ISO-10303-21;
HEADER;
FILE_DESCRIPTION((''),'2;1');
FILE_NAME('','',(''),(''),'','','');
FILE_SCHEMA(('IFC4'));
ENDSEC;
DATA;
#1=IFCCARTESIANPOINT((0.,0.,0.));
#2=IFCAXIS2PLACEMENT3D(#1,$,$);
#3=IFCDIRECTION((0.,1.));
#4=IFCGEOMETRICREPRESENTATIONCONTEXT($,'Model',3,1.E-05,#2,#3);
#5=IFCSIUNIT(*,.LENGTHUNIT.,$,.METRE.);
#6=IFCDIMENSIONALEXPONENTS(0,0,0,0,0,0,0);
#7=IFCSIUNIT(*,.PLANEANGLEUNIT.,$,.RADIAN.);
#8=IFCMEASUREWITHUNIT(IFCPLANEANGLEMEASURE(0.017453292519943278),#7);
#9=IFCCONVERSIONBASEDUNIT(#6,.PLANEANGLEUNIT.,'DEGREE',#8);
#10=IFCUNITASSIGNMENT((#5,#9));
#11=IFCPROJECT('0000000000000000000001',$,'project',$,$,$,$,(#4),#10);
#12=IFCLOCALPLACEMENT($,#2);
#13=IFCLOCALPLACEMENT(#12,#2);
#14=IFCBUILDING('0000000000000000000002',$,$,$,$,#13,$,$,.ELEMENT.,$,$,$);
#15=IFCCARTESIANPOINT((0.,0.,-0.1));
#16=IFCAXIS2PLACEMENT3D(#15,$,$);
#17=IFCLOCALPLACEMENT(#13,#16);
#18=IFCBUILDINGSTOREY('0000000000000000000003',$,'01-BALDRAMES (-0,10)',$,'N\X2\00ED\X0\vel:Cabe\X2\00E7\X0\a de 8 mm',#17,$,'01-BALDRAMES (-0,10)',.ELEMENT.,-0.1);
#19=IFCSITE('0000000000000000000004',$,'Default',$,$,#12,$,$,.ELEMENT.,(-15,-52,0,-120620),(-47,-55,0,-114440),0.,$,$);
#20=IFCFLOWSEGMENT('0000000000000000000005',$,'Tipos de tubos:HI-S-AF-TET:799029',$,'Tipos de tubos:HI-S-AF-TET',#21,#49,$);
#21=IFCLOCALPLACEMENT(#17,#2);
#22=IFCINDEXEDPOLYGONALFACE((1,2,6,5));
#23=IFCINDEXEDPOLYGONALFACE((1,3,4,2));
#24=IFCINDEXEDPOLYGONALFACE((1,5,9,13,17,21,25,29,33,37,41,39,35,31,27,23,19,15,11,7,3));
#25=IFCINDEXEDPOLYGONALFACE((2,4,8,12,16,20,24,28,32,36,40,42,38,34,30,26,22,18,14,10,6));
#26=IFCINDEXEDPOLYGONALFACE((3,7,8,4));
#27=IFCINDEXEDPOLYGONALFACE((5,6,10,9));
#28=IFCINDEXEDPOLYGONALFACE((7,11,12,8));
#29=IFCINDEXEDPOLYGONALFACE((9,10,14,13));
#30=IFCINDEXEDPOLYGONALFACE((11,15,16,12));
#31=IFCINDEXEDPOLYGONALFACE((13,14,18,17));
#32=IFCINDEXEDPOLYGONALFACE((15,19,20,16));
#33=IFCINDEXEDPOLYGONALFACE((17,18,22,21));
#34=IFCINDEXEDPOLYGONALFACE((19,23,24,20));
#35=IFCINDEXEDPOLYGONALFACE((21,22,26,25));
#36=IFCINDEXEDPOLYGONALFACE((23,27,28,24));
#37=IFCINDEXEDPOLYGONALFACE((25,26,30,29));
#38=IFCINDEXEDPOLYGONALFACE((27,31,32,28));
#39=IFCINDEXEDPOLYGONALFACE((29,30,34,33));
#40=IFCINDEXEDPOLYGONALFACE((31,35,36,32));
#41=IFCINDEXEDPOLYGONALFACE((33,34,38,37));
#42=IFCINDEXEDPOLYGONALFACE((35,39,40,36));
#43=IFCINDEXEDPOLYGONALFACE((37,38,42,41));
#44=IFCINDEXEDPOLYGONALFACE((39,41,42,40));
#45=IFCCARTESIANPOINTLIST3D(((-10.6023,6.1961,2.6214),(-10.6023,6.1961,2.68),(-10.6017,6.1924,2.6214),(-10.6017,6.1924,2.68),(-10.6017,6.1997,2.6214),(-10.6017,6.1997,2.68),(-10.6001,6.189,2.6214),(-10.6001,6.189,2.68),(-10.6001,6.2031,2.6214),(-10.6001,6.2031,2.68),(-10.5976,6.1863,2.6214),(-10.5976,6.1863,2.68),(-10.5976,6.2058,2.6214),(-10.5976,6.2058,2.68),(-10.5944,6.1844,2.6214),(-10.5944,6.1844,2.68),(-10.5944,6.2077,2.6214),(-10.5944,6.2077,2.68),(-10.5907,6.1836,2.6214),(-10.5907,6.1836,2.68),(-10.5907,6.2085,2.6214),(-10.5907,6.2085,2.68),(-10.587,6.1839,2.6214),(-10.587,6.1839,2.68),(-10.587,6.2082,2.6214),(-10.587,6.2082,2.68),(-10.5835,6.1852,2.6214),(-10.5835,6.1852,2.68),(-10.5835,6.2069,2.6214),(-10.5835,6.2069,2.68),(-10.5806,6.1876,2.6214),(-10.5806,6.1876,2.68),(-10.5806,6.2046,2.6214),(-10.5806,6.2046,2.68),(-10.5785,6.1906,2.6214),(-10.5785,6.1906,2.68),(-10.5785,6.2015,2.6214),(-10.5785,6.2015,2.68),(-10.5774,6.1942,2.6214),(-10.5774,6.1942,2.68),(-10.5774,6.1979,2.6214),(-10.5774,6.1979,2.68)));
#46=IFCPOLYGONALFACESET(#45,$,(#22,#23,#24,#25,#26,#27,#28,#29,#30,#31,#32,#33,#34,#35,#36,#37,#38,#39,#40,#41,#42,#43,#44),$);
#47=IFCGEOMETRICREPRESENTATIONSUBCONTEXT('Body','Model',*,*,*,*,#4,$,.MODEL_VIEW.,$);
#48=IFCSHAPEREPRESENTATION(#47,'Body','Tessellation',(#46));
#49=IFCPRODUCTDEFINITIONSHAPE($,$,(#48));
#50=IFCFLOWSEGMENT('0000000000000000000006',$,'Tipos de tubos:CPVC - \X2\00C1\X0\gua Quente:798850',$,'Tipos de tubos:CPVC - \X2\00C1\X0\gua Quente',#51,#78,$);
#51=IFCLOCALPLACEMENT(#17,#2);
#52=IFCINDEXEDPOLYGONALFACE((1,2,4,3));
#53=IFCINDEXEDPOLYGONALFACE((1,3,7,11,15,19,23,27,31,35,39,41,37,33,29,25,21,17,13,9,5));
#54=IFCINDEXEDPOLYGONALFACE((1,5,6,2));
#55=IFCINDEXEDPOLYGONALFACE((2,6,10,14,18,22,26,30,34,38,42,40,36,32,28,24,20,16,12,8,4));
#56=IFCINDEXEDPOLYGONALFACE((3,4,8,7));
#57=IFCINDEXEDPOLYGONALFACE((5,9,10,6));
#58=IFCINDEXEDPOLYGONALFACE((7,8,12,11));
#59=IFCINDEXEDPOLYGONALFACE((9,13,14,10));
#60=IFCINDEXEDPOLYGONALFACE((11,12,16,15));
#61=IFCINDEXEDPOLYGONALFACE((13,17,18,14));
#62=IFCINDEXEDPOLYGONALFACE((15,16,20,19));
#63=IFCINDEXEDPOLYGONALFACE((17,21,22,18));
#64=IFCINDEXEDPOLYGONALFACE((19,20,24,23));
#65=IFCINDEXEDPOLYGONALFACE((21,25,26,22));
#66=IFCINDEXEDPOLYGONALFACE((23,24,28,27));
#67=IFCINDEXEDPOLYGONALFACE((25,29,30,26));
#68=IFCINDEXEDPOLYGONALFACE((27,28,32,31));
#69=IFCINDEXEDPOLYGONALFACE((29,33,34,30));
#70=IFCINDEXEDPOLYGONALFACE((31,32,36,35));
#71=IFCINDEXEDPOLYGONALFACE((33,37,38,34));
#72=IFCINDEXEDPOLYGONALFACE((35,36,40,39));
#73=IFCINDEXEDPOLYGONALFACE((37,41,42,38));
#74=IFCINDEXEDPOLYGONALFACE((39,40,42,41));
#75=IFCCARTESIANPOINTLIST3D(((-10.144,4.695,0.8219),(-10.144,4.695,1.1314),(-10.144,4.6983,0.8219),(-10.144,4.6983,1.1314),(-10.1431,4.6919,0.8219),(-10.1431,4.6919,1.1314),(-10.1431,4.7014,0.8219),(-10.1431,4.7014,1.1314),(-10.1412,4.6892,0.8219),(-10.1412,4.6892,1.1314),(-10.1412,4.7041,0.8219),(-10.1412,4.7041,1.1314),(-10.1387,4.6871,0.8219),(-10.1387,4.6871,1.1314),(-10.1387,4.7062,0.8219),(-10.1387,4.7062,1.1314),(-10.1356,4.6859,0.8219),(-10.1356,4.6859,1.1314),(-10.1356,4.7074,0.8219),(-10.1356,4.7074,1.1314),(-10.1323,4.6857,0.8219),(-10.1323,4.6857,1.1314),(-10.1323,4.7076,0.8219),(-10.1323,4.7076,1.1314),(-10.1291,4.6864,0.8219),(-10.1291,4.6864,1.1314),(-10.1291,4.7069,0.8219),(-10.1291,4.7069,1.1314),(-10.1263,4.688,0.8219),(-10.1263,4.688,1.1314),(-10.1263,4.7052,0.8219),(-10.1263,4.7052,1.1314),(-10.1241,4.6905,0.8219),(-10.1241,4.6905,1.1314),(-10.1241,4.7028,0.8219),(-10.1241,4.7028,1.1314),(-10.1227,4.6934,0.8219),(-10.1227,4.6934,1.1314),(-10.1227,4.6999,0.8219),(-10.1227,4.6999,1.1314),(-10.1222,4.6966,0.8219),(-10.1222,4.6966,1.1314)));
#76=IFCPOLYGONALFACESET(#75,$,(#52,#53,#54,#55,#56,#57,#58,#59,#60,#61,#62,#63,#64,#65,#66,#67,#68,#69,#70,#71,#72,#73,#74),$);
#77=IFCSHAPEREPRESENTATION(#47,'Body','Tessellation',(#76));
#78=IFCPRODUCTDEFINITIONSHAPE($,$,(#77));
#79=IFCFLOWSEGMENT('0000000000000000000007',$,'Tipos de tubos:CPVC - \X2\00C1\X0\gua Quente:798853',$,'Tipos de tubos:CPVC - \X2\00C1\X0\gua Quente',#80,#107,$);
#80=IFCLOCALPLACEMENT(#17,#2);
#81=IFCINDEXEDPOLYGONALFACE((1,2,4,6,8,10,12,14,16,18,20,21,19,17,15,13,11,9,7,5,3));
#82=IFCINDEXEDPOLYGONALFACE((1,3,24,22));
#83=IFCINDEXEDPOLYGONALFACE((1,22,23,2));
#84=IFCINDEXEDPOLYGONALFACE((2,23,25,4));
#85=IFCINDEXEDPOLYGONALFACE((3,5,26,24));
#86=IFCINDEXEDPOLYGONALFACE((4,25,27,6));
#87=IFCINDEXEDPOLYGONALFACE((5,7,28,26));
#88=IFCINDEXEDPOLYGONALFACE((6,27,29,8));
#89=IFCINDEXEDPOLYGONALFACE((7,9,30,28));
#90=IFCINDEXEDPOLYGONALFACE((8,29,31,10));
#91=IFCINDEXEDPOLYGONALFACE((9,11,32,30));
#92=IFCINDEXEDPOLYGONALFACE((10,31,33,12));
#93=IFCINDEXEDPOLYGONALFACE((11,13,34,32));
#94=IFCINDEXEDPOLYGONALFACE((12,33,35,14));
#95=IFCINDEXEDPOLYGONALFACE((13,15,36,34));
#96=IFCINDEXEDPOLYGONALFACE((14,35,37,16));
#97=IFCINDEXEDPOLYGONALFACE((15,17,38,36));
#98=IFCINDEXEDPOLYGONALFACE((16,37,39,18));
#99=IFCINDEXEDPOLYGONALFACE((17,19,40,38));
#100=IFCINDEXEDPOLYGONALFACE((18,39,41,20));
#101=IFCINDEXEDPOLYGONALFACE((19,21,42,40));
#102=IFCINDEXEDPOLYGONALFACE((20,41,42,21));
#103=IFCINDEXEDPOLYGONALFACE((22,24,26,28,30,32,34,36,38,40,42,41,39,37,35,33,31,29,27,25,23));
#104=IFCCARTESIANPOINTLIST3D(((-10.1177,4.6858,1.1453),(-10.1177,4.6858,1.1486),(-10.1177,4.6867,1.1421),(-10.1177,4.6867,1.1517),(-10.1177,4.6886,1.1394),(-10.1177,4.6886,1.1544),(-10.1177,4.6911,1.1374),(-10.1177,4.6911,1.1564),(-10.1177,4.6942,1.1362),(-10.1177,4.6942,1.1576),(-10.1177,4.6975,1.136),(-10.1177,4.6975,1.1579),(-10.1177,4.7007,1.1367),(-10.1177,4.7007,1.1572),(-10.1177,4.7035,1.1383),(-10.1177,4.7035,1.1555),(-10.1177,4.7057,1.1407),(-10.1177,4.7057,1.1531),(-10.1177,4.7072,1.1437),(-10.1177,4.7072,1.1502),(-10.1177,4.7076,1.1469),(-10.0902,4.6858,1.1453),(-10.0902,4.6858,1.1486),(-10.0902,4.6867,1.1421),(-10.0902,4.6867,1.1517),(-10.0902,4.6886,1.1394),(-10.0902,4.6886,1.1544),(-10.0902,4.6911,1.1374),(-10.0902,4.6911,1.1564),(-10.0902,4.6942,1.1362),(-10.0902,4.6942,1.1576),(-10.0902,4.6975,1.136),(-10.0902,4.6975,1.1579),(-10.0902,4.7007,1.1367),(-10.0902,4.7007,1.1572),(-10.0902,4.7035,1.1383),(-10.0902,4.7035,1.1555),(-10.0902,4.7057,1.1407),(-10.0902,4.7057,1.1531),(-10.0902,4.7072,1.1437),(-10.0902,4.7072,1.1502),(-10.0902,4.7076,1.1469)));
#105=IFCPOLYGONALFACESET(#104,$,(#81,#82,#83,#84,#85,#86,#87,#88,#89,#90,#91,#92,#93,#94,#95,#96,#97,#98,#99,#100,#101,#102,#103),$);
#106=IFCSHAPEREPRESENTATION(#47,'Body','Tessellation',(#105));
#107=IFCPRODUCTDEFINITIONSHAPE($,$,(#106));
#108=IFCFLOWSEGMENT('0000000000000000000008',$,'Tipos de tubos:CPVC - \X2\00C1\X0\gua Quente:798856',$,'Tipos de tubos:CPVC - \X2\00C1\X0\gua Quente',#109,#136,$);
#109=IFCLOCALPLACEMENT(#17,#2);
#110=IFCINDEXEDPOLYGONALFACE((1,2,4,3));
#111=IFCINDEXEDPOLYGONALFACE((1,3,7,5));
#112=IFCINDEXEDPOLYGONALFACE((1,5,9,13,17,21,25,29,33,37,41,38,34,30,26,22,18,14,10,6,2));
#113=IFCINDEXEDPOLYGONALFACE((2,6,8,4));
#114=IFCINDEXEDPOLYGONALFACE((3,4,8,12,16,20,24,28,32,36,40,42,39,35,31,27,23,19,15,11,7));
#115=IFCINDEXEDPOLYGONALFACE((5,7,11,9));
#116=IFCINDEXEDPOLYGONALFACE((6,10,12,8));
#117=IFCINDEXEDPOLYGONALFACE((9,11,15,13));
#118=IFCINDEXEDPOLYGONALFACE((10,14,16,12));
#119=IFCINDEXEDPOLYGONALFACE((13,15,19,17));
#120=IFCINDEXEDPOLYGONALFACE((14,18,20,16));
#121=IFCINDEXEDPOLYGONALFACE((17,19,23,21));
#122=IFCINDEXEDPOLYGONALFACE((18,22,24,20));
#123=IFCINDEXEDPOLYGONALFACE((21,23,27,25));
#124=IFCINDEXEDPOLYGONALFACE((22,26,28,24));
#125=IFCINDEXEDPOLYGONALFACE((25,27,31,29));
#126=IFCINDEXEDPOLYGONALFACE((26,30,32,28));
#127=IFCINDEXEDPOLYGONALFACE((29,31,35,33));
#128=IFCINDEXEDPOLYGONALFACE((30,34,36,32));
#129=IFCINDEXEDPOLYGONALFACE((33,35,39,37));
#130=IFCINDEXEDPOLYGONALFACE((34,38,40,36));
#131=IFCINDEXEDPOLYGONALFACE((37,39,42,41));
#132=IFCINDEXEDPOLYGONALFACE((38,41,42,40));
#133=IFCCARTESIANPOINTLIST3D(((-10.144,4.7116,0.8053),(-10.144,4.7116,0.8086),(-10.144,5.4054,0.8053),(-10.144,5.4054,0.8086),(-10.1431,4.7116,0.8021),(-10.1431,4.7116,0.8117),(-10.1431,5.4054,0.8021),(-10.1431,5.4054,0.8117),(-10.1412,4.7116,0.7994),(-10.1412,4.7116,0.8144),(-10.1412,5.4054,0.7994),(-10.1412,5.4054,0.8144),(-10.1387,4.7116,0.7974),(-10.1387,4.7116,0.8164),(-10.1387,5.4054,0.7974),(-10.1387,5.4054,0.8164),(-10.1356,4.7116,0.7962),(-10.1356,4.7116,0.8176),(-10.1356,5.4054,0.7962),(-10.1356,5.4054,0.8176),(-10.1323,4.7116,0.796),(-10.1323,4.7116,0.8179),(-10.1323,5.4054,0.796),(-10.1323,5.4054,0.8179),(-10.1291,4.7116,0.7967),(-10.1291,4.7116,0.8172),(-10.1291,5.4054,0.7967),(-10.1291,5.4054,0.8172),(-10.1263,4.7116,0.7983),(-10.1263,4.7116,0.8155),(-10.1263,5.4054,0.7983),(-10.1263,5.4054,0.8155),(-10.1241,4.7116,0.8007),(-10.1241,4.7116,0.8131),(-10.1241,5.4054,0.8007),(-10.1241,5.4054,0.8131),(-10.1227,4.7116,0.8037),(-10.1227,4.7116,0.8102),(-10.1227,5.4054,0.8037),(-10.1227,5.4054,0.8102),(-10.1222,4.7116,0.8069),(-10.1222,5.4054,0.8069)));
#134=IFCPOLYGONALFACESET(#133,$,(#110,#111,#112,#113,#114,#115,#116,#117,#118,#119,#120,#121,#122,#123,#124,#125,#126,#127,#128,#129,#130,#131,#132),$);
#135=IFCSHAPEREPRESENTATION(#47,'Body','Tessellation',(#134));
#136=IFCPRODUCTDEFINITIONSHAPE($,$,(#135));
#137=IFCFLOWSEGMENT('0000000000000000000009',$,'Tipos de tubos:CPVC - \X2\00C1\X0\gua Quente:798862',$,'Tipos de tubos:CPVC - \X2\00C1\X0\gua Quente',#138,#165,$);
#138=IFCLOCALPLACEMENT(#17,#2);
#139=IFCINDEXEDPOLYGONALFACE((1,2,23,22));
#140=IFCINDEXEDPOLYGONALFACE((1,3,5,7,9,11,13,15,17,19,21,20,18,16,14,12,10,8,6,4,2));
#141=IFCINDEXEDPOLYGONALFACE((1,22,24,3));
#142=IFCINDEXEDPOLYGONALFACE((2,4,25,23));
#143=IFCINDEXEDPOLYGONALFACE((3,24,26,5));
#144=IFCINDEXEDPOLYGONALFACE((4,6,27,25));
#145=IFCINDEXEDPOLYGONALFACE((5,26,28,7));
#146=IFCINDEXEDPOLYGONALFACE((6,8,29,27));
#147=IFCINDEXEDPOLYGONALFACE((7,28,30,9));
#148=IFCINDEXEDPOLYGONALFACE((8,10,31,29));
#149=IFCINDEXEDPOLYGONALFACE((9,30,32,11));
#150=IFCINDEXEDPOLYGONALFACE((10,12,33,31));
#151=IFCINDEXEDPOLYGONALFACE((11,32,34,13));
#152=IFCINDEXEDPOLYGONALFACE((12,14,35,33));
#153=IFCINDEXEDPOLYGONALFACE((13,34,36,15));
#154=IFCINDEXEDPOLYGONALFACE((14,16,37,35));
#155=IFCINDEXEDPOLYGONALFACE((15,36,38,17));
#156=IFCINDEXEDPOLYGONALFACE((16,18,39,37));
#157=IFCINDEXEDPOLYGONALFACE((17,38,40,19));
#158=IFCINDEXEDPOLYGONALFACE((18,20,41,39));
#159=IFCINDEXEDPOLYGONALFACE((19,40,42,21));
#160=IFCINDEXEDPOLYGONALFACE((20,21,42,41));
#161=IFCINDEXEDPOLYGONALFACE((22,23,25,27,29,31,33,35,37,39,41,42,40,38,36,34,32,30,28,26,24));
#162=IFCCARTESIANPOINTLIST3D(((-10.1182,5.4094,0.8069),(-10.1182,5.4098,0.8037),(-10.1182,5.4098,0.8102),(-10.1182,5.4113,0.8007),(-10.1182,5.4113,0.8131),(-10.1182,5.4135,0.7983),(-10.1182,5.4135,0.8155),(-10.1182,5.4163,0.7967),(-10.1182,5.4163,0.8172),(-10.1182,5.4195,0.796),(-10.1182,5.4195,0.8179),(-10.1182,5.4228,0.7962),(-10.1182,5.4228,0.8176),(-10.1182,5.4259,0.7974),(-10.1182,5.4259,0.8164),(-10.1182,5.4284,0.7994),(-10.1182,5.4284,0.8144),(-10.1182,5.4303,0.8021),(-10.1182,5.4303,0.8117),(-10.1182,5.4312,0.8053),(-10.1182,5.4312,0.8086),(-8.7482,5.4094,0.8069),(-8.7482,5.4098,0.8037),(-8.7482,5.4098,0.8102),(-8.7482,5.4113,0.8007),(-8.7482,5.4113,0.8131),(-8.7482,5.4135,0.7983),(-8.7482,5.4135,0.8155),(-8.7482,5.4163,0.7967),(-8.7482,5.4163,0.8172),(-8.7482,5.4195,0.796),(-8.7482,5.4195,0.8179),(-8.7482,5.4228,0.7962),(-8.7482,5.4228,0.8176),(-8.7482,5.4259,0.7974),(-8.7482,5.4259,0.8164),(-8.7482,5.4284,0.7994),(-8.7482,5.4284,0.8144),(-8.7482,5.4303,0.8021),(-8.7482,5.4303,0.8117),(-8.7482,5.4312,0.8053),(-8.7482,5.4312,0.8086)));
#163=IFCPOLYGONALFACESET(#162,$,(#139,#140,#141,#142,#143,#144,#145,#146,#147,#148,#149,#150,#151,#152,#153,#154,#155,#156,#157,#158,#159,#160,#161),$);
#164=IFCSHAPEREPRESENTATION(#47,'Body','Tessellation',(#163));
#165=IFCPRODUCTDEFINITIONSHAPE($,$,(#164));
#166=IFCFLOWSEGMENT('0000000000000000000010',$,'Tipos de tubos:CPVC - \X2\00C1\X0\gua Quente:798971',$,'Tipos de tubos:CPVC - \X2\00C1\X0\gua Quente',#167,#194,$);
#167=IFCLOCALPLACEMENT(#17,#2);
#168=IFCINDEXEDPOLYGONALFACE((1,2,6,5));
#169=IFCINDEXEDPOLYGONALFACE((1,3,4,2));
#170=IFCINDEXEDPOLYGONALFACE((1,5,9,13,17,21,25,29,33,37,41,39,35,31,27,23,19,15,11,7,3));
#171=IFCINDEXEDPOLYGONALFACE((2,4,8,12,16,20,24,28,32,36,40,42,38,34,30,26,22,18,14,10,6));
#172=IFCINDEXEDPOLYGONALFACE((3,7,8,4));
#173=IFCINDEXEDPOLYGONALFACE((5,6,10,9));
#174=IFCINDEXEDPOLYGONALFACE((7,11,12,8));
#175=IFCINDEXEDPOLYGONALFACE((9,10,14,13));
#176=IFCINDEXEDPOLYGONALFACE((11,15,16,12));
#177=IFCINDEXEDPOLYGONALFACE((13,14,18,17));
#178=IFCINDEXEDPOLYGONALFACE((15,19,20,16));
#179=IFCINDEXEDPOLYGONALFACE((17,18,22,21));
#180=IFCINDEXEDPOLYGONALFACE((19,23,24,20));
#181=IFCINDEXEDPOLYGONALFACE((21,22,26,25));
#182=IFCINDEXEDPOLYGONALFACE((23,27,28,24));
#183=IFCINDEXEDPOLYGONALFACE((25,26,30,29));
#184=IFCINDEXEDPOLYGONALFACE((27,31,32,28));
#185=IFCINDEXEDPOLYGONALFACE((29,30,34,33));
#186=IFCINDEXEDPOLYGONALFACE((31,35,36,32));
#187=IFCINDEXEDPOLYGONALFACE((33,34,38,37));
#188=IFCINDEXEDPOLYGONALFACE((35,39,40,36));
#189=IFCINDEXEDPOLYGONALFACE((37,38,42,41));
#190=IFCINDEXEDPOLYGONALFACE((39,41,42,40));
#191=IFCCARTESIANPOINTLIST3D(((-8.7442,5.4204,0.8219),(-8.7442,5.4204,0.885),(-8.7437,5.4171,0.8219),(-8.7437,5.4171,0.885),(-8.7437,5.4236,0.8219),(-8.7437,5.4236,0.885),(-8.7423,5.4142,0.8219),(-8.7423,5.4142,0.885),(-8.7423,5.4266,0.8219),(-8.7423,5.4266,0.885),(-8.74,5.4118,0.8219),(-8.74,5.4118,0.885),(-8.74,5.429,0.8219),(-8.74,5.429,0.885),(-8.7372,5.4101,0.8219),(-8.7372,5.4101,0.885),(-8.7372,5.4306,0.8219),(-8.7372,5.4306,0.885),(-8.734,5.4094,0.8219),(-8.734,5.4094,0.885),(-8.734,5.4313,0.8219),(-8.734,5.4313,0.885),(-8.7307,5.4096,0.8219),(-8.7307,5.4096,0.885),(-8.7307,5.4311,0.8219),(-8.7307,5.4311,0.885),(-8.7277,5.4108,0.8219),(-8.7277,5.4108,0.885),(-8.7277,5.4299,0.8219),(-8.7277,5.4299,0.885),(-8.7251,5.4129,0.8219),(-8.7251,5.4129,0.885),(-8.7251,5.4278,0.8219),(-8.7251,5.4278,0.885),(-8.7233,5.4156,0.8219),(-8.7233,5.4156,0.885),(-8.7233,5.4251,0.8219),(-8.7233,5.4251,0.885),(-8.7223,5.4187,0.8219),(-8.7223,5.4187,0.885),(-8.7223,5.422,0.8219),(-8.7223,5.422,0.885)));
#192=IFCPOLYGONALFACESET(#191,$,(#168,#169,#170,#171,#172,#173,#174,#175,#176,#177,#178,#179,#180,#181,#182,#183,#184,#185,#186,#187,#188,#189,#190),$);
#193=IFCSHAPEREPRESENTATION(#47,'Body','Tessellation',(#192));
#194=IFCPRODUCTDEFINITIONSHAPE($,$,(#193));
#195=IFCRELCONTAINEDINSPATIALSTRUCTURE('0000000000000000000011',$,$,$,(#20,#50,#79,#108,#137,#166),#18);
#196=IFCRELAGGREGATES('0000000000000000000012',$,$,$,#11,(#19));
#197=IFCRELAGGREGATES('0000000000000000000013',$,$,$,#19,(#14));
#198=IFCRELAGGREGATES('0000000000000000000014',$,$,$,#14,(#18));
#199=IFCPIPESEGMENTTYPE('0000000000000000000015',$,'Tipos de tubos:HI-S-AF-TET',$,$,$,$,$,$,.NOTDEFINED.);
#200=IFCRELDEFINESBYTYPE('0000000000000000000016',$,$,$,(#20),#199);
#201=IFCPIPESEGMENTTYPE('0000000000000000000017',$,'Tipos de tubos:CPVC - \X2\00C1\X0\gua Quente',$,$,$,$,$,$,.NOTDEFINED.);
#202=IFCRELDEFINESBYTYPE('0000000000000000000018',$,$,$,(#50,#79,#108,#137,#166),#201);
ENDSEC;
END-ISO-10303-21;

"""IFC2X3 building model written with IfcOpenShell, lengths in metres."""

from ifc_helpers import new_model, entity, si_unit, converted_unit, direction, frame, frame_2d, origin, origin_2d_with_axis, place, context, subcontext, project, spatial, circle, extrude, type_object, element, save


model = new_model("IFC2X3")

# Units and contexts
model_context = context("Model", 3, precision=1e-05, world=origin(), true_north=direction((0.0, 1.0)))
body_context = subcontext(model_context, "Body", "Model", "MODEL_VIEW")
ifc_project = project(units=[si_unit("LENGTHUNIT", "METRE"), converted_unit("PLANEANGLEUNIT", "DEGREE", entity("IfcPlaneAngleMeasure", 0.017453292519943278), si_unit("PLANEANGLEUNIT", "RADIAN"), dimensions=[0, 0, 0, 0, 0, 0, 0])], contexts=[model_context])

# Site, building, storey
site_placement = place(None, origin())
site = spatial("IfcSite", under=ifc_project, at=site_placement, Name="Default", CompositionType="ELEMENT", RefLatitude=(-15, -52, 0, -120620), RefLongitude=(-47, -55, 0, -114440), RefElevation=0.0)
building_placement = place(site_placement, origin())
building = spatial("IfcBuilding", under=site, at=building_placement, CompositionType="ELEMENT")
storey_placement = place(building_placement, frame((0.0, 0.0, -0.1)))
storey = spatial("IfcBuildingStorey", under=building, at=storey_placement, Name="01-BALDRAMES (-0,10)", ObjectType="Nível:Cabeça de 8 mm", LongName="01-BALDRAMES (-0,10)", CompositionType="ELEMENT", Elevation=-0.1)

# Flow segments
pipe_segment_type_1 = type_object("IfcPipeSegmentType", Name="Tipos de tubos:HI-S-AF-TET", PredefinedType="NOTDEFINED")
flow_segment_1_placement = place(storey_placement, origin())
element("IfcFlowSegment", 1, at=flow_segment_1_placement, inside=storey, type_object=pipe_segment_type_1, Name="Tipos de tubos:HI-S-AF-TET:799029", ObjectType="Tipos de tubos:HI-S-AF-TET", context=body_context, shape_type="SweptSolid", body=[
    extrude(circle(Radius=0.0125, at=origin_2d_with_axis()), frame((-10.5898, 6.1961, 2.6214), z_axis=(0.0, 0.0, 1.0), x_axis=(-1.0, 0.0, 0.0)), (0.0, 0.0, 1.0), 0.0586),
])
pipe_segment_type_2 = type_object("IfcPipeSegmentType", Name="Tipos de tubos:CPVC - Água Quente", PredefinedType="NOTDEFINED")
flow_segment_2_placement = place(storey_placement, origin())
element("IfcFlowSegment", 2, at=flow_segment_2_placement, inside=storey, type_object=pipe_segment_type_2, Name="Tipos de tubos:CPVC - Água Quente:798850", ObjectType="Tipos de tubos:CPVC - Água Quente", context=body_context, shape_type="SweptSolid", body=[
    extrude(circle(Radius=0.011, at=frame_2d((0.0, 0.0), x_axis=(1.0, 0.0))), frame((-10.1332, 4.6966, 0.8219)), (0.0, 0.0, 1.0), 0.3095),
])
flow_segment_3_placement = place(storey_placement, origin())
element("IfcFlowSegment", 3, at=flow_segment_3_placement, inside=storey, type_object=pipe_segment_type_2, Name="Tipos de tubos:CPVC - Água Quente:798853", ObjectType="Tipos de tubos:CPVC - Água Quente", context=body_context, shape_type="SweptSolid", body=[
    extrude(circle(Radius=0.011, at=frame_2d((0.0, 0.0), x_axis=(1.0, 0.0))), frame((-10.1177, 4.6966, 1.1469), z_axis=(1.0, 0.0, 0.0), x_axis=(0.0, 1.0, 0.0)), (0.0, 0.0, 1.0), 0.0274),
])
flow_segment_4_placement = place(storey_placement, origin())
element("IfcFlowSegment", 4, at=flow_segment_4_placement, inside=storey, type_object=pipe_segment_type_2, Name="Tipos de tubos:CPVC - Água Quente:798856", ObjectType="Tipos de tubos:CPVC - Água Quente", context=body_context, shape_type="SweptSolid", body=[
    extrude(circle(Radius=0.011, at=origin_2d_with_axis()), frame((-10.1332, 4.7116, 0.8069), z_axis=(0.0, 1.0, 0.0), x_axis=(1.0, 0.0, 0.0)), (0.0, 0.0, 1.0), 0.6937),
])
flow_segment_5_placement = place(storey_placement, origin())
element("IfcFlowSegment", 5, at=flow_segment_5_placement, inside=storey, type_object=pipe_segment_type_2, Name="Tipos de tubos:CPVC - Água Quente:798862", ObjectType="Tipos de tubos:CPVC - Água Quente", context=body_context, shape_type="SweptSolid", body=[
    extrude(circle(Radius=0.011, at=origin_2d_with_axis()), frame((-10.1182, 5.4204, 0.8069), z_axis=(1.0, 0.0, 0.0), x_axis=(0.0, -1.0, 0.0)), (0.0, 0.0, 1.0), 1.37),
])
flow_segment_6_placement = place(storey_placement, origin())
element("IfcFlowSegment", 6, at=flow_segment_6_placement, inside=storey, type_object=pipe_segment_type_2, Name="Tipos de tubos:CPVC - Água Quente:798971", ObjectType="Tipos de tubos:CPVC - Água Quente", context=body_context, shape_type="SweptSolid", body=[
    extrude(circle(Radius=0.011, at=origin_2d_with_axis()), frame((-8.7332, 5.4204, 0.8219), z_axis=(0.0, 0.0, 1.0), x_axis=(-1.0, 0.0, 0.0)), (0.0, 0.0, 1.0), 0.0631),
])

save(model, "model.ifc")
